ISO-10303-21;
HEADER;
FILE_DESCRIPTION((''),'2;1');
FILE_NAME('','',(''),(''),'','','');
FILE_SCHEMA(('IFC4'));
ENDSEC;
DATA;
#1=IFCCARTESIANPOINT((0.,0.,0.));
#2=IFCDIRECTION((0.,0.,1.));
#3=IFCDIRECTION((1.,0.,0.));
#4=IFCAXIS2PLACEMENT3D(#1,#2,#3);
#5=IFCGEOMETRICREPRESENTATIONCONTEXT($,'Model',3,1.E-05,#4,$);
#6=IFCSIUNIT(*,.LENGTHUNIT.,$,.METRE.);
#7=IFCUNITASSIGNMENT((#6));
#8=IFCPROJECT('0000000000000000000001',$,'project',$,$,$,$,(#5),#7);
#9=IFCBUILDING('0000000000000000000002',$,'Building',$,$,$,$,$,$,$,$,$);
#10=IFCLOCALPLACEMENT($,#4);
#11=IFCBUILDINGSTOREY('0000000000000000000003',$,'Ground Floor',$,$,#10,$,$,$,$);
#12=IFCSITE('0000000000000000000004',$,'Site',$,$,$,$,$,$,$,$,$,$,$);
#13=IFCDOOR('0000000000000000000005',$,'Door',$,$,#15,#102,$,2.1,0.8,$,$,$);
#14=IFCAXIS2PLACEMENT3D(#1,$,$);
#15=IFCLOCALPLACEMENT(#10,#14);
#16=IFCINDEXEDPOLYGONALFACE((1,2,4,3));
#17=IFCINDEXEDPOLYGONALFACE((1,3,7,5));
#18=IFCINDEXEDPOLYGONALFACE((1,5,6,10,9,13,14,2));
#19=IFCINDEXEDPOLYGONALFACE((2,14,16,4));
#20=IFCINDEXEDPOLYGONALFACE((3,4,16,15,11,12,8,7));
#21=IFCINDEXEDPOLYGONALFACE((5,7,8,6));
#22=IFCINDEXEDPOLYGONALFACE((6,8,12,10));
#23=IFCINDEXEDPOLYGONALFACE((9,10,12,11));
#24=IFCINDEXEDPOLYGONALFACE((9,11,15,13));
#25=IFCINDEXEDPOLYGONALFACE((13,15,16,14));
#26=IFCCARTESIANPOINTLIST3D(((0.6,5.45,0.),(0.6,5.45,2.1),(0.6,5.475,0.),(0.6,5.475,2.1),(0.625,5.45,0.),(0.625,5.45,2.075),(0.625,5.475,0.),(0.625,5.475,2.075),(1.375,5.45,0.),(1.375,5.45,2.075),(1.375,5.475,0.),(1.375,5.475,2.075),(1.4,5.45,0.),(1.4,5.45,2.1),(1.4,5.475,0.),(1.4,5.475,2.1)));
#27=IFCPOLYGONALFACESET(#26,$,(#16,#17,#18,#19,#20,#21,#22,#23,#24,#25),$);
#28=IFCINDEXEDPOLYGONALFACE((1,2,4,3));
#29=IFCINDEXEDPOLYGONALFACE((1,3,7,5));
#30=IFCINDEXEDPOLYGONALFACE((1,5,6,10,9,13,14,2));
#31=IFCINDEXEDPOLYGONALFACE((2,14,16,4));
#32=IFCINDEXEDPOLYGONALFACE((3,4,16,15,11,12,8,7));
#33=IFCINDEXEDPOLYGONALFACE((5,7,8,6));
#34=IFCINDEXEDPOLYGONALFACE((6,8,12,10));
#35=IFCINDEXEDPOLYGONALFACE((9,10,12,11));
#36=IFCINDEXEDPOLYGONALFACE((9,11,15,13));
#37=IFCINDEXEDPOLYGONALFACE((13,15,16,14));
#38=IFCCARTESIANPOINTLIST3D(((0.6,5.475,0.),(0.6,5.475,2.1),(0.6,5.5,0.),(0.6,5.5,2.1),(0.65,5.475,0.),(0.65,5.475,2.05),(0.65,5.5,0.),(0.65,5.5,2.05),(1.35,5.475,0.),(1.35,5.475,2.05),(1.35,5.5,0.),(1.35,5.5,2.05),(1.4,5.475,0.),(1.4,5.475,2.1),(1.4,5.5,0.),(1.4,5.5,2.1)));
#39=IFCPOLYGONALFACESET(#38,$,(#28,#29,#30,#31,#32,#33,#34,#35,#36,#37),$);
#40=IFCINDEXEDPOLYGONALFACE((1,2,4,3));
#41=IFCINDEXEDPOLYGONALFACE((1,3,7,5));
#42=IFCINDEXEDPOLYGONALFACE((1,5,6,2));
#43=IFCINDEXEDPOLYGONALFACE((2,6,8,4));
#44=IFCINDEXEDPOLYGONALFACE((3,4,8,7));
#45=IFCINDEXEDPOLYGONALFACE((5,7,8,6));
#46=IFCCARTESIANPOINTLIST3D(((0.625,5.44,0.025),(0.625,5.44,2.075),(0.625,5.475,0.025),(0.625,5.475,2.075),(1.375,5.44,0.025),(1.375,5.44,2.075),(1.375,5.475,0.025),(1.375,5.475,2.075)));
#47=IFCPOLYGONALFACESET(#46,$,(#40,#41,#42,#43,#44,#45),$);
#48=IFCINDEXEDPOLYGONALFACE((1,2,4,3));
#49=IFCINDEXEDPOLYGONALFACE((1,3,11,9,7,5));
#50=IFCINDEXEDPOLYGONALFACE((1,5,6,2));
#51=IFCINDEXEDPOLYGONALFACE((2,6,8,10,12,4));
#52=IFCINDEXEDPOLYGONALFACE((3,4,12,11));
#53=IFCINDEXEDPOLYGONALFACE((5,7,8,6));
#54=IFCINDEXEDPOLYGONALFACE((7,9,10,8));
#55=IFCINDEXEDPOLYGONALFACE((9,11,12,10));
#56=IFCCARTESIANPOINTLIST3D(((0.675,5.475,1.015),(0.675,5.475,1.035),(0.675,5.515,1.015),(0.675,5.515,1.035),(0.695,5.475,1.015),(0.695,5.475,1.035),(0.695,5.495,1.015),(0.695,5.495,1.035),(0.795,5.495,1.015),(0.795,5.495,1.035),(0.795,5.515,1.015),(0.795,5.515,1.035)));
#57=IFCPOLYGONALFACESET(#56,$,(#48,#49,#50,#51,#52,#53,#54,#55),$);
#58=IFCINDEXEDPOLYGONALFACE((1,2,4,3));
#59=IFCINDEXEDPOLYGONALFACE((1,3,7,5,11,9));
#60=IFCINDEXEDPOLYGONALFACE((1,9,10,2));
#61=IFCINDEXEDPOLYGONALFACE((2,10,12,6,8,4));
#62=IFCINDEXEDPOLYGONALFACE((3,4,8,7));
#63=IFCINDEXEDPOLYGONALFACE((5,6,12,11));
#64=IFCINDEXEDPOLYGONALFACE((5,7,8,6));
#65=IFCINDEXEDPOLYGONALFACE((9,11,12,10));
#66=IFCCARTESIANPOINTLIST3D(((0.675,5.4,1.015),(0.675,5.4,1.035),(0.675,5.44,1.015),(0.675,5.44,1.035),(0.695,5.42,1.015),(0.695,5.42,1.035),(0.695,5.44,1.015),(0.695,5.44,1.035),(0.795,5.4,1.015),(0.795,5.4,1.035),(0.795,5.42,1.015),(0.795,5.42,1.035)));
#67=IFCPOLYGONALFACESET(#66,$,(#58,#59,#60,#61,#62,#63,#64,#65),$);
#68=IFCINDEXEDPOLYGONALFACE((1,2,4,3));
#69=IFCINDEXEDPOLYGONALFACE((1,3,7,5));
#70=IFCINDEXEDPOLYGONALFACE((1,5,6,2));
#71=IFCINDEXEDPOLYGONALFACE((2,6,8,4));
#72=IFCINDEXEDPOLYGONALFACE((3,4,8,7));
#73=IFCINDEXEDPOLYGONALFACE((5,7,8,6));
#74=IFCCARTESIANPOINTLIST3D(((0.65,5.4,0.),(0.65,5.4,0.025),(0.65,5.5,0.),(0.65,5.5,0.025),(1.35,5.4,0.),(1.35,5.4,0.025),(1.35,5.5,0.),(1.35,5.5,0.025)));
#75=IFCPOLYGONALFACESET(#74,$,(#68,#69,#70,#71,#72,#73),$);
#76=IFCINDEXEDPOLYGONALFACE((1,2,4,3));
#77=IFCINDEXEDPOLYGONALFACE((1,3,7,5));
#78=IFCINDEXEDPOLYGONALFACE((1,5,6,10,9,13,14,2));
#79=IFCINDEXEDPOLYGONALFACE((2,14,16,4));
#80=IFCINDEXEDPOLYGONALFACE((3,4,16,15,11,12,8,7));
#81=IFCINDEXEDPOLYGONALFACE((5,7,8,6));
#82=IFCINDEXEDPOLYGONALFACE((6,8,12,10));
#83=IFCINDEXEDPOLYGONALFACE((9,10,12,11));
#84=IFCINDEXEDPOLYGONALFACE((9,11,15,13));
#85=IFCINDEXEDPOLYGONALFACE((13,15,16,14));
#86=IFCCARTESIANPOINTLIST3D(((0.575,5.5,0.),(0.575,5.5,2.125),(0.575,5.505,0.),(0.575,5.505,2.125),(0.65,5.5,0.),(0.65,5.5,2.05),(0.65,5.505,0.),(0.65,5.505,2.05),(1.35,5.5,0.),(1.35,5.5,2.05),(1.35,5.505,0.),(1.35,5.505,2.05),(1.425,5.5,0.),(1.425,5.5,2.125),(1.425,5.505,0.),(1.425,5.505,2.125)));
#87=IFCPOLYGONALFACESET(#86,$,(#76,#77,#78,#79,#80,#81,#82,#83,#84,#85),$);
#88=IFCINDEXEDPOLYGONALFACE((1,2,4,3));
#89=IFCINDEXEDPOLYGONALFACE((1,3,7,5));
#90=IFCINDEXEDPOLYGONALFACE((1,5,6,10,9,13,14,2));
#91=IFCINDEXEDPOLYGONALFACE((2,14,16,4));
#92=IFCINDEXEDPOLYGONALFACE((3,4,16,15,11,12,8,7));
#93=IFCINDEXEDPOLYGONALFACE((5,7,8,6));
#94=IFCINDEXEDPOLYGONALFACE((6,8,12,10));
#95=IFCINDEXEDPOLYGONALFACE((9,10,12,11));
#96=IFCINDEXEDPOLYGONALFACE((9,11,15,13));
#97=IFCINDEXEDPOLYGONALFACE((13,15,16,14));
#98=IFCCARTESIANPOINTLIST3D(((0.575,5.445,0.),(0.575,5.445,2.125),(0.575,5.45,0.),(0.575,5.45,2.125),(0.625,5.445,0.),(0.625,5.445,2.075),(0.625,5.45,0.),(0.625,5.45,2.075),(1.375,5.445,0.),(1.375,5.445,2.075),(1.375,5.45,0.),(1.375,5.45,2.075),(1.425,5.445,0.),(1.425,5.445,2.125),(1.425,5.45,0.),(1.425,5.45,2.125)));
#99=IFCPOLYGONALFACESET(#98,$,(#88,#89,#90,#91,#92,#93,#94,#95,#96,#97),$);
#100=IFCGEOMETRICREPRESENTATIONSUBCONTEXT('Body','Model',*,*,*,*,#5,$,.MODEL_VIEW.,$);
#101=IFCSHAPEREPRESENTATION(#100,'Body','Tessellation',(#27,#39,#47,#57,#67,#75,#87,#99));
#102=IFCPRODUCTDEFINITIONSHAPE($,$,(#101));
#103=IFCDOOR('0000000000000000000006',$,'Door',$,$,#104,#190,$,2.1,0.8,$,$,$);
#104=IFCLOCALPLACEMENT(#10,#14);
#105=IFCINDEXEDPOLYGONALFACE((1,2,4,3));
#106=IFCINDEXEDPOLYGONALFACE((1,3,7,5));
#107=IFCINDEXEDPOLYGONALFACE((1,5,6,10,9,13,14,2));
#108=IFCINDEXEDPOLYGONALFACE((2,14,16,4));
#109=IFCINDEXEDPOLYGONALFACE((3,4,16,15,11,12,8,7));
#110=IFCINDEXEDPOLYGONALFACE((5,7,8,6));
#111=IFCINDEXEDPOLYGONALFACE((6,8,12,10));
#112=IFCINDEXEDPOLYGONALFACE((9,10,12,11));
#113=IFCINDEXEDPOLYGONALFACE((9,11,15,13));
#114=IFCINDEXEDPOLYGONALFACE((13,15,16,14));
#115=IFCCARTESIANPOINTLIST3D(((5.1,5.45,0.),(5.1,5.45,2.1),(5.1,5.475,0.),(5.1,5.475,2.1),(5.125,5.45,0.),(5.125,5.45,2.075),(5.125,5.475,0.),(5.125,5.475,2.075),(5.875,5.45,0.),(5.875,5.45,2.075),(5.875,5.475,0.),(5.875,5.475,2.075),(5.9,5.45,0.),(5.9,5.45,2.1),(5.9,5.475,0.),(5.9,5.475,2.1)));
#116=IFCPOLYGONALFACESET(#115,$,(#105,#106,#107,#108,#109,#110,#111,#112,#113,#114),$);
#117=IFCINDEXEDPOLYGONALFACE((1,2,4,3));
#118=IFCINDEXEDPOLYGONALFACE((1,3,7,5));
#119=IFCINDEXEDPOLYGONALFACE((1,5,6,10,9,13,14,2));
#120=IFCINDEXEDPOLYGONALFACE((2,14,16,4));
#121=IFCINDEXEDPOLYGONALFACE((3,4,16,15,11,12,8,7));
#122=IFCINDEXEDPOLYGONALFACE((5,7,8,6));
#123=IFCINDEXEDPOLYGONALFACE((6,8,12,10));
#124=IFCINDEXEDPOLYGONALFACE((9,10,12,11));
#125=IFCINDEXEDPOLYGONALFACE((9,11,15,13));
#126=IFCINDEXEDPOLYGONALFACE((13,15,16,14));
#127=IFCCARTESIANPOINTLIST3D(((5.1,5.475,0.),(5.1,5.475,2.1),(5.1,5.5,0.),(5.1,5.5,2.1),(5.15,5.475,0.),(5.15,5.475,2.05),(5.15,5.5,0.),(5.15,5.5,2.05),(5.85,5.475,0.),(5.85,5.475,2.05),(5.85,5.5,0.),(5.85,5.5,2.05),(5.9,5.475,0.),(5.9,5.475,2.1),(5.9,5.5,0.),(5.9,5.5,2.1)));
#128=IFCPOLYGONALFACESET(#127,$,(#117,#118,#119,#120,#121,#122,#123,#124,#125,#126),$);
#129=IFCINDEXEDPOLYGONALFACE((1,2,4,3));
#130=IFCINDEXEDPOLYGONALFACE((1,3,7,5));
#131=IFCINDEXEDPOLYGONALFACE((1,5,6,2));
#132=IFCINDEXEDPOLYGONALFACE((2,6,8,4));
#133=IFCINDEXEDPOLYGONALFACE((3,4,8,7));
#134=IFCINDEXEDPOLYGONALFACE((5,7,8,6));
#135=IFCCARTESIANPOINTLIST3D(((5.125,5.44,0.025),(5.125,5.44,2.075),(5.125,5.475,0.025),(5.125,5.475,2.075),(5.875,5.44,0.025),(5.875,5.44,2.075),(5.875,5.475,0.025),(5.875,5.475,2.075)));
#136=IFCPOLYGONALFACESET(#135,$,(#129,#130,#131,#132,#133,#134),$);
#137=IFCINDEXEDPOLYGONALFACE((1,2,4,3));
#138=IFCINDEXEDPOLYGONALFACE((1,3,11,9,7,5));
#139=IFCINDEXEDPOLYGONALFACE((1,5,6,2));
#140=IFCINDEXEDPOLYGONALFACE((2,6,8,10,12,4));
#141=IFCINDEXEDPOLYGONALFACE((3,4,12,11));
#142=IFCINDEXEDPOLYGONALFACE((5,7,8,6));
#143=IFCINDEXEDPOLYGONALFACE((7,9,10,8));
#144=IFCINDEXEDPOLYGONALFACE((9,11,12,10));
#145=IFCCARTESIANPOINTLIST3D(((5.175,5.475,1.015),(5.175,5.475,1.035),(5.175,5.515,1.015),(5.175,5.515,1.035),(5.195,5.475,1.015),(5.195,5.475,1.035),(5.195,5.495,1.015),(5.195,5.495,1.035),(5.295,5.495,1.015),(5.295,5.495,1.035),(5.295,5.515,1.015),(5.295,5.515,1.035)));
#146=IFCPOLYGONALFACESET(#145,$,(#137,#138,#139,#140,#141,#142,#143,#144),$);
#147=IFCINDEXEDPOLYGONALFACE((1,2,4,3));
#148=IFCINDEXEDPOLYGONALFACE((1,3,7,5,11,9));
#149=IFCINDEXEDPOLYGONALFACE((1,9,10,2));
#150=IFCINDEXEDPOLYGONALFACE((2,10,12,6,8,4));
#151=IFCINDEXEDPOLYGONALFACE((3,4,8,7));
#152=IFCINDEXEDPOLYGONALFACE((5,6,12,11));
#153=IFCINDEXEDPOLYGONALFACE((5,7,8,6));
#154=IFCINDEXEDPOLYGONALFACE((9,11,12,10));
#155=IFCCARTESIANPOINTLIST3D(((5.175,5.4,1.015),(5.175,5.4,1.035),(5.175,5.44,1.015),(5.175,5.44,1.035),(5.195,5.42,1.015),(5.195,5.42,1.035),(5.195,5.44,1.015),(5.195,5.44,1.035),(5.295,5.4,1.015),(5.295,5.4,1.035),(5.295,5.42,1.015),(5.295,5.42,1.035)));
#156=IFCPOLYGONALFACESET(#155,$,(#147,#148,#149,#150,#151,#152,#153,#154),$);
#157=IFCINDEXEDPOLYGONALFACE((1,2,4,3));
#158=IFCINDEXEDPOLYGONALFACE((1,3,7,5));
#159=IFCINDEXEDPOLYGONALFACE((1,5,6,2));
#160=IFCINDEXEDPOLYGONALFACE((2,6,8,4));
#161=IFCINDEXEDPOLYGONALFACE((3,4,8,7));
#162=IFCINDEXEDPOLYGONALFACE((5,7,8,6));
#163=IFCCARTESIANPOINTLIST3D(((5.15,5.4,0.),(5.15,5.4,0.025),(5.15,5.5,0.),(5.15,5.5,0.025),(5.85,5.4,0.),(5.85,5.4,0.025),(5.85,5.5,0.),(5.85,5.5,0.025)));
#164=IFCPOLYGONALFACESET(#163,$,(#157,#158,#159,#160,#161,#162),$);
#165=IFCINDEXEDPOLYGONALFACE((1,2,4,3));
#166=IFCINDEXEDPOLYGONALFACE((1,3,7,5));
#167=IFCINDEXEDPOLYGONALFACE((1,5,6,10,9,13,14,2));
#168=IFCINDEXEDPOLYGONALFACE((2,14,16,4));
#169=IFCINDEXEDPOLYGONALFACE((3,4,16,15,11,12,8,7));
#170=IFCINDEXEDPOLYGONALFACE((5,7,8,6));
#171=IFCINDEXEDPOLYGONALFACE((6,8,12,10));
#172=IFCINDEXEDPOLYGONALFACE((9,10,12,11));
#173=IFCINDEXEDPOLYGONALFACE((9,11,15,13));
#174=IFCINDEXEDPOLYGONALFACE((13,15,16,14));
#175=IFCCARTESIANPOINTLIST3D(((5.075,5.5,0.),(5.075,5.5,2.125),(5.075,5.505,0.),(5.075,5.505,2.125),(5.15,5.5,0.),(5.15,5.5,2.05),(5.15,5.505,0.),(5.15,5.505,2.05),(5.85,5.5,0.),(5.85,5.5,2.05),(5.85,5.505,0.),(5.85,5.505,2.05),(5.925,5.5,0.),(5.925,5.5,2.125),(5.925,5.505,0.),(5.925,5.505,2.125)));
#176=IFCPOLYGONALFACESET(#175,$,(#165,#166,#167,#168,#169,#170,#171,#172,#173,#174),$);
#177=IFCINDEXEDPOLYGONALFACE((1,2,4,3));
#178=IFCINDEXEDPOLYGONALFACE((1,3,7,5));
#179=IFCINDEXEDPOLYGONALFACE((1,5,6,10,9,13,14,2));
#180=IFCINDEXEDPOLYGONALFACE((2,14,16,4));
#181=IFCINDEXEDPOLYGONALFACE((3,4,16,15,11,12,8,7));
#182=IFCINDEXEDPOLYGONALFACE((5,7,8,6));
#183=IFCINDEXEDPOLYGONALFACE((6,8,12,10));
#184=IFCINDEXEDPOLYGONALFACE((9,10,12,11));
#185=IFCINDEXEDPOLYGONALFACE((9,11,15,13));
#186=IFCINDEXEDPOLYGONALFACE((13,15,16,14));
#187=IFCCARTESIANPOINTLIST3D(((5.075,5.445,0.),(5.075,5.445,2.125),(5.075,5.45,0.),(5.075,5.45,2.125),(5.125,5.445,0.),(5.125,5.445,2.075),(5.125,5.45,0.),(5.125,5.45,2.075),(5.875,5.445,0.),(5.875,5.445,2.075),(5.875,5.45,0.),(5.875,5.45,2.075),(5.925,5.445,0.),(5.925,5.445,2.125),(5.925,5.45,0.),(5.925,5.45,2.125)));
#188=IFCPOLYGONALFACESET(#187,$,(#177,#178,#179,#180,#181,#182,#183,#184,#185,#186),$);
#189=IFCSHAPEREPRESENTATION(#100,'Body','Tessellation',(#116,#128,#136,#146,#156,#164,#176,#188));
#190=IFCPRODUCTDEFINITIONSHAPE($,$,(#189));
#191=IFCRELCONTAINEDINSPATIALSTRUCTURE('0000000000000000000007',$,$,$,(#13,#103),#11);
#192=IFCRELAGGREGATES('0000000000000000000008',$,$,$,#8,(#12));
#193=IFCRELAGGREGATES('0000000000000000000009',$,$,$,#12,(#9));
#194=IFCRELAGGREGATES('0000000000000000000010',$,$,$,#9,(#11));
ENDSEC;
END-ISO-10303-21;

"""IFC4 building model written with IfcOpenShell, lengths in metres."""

from ifc_helpers import new_model, si_unit, frame, origin_with_axes, place, context, subcontext, project, spatial, line, indexed_curve, outline, extrude, element, save


model = new_model("IFC4")

# Units and contexts
model_context = context("Model", 3, precision=1e-05, world=origin_with_axes())
body_context = subcontext(model_context, "Body", "Model", "MODEL_VIEW")
ifc_project = project(units=[si_unit("LENGTHUNIT", "METRE")], contexts=[model_context])

# Site, building, storey
site = spatial("IfcSite", under=ifc_project, Name="Site")
building = spatial("IfcBuilding", under=site, Name="Building")
storey_placement = place(None, origin_with_axes())
storey = spatial("IfcBuildingStorey", under=building, at=storey_placement, Name="Ground Floor")

# Doors
door_1_placement = place(storey_placement, frame((1.4, 5.5, 0.0), z_axis=(0.0, 0.0, 1.0), x_axis=(-1.0, 0.0, 0.0)))
element("IfcDoor", 1, at=door_1_placement, inside=storey, Name="Door", OverallHeight=2.1, OverallWidth=0.8, context=body_context, shape_type="SweptSolid", body=[
    extrude(outline(indexed_curve([(0.0, 0.0), (0.0, 2.1), (0.8, 2.1), (0.8, 0.0), (0.775, 0.0), (0.775, 2.075), (0.025, 2.075), (0.025, 0.0)], segments=[line(1, 2, 3, 4, 5, 6, 7, 8, 1)])), frame((0.0, 0.025, 0.0), z_axis=(0.0, -1.0, 0.0), x_axis=(1.0, 0.0, 0.0)), (0.0, 0.0, -1.0), 0.025),
    extrude(outline(indexed_curve([(0.0, 0.0), (0.0, 2.1), (0.8, 2.1), (0.8, 0.0), (0.75, 0.0), (0.75, 2.05), (0.05, 2.05), (0.05, 0.0)], segments=[line(1, 2, 3, 4, 5, 6, 7, 8, 1)])), frame((0.0, 0.0, 0.0), z_axis=(0.0, -1.0, 0.0), x_axis=(1.0, 0.0, 0.0)), (0.0, 0.0, -1.0), 0.025),
    extrude(outline(indexed_curve([(0.0, 0.0), (0.75, 0.0), (0.75, 0.035), (0.0, 0.035)], segments=[line(1, 2, 3, 4, 1)])), frame((0.025, 0.025, 0.025), z_axis=(0.0, 0.0, 1.0), x_axis=(1.0, 0.0, 0.0)), (0.0, 0.0, 1.0), 2.05),
    extrude(outline(indexed_curve([(0.0, 0.0), (0.0, -0.04), (-0.12, -0.04), (-0.12, -0.02), (-0.02, -0.02), (-0.02, 0.0)], segments=[line(1, 2, 3, 4, 5, 6, 1)])), frame((0.725, 0.025, 1.015), z_axis=(0.0, 0.0, 1.0), x_axis=(1.0, 0.0, 0.0)), (0.0, 0.0, 1.0), 0.02),
    extrude(outline(indexed_curve([(0.0, 0.0), (0.0, 0.04), (-0.12, 0.04), (-0.12, 0.02), (-0.02, 0.02), (-0.02, 0.0)], segments=[line(1, 2, 3, 4, 5, 6, 1)])), frame((0.725, 0.06, 1.015), z_axis=(0.0, 0.0, 1.0), x_axis=(1.0, 0.0, 0.0)), (0.0, 0.0, 1.0), 0.02),
    extrude(outline(indexed_curve([(0.0, 0.0), (0.7, 0.0), (0.7, 0.1), (0.0, 0.1)], segments=[line(1, 2, 3, 4, 1)])), frame((0.05, 0.0, 0.0), z_axis=(0.0, 0.0, 1.0), x_axis=(1.0, 0.0, 0.0)), (0.0, 0.0, 1.0), 0.025),
    extrude(outline(indexed_curve([(0.0, 0.0), (0.0, 2.125), (0.85, 2.125), (0.85, 0.0), (0.775, 0.0), (0.775, 2.05), (0.075, 2.05), (0.075, 0.0)], segments=[line(1, 2, 3, 4, 5, 6, 7, 8, 1)])), frame((-0.025, -0.005, 0.0), z_axis=(0.0, -1.0, 0.0), x_axis=(1.0, 0.0, 0.0)), (0.0, 0.0, -1.0), 0.005),
    extrude(outline(indexed_curve([(0.0, 0.0), (0.0, 2.125), (0.85, 2.125), (0.85, 0.0), (0.8, 0.0), (0.8, 2.075), (0.05, 2.075), (0.05, 0.0)], segments=[line(1, 2, 3, 4, 5, 6, 7, 8, 1)])), frame((-0.025, 0.05, 0.0), z_axis=(0.0, -1.0, 0.0), x_axis=(1.0, 0.0, 0.0)), (0.0, 0.0, -1.0), 0.005),
])
door_2_placement = place(storey_placement, frame((5.9, 5.5, 0.0), z_axis=(0.0, 0.0, 1.0), x_axis=(-1.0, 0.0, 0.0)))
element("IfcDoor", 2, at=door_2_placement, inside=storey, Name="Door", OverallHeight=2.1, OverallWidth=0.8, context=body_context, shape_type="SweptSolid", body=[
    extrude(outline(indexed_curve([(0.0, 0.0), (0.0, 2.1), (0.8, 2.1), (0.8, 0.0), (0.775, 0.0), (0.775, 2.075), (0.025, 2.075), (0.025, 0.0)], segments=[line(1, 2, 3, 4, 5, 6, 7, 8, 1)])), frame((0.0, 0.025, 0.0), z_axis=(0.0, -1.0, 0.0), x_axis=(1.0, 0.0, 0.0)), (0.0, 0.0, -1.0), 0.025),
    extrude(outline(indexed_curve([(0.0, 0.0), (0.0, 2.1), (0.8, 2.1), (0.8, 0.0), (0.75, 0.0), (0.75, 2.05), (0.05, 2.05), (0.05, 0.0)], segments=[line(1, 2, 3, 4, 5, 6, 7, 8, 1)])), frame((0.0, 0.0, 0.0), z_axis=(0.0, -1.0, 0.0), x_axis=(1.0, 0.0, 0.0)), (0.0, 0.0, -1.0), 0.025),
    extrude(outline(indexed_curve([(0.0, 0.0), (0.75, 0.0), (0.75, 0.035), (0.0, 0.035)], segments=[line(1, 2, 3, 4, 1)])), frame((0.025, 0.025, 0.025), z_axis=(0.0, 0.0, 1.0), x_axis=(1.0, 0.0, 0.0)), (0.0, 0.0, 1.0), 2.05),
    extrude(outline(indexed_curve([(0.0, 0.0), (0.0, -0.04), (-0.12, -0.04), (-0.12, -0.02), (-0.02, -0.02), (-0.02, 0.0)], segments=[line(1, 2, 3, 4, 5, 6, 1)])), frame((0.725, 0.025, 1.015), z_axis=(0.0, 0.0, 1.0), x_axis=(1.0, 0.0, 0.0)), (0.0, 0.0, 1.0), 0.02),
    extrude(outline(indexed_curve([(0.0, 0.0), (0.0, 0.04), (-0.12, 0.04), (-0.12, 0.02), (-0.02, 0.02), (-0.02, 0.0)], segments=[line(1, 2, 3, 4, 5, 6, 1)])), frame((0.725, 0.06, 1.015), z_axis=(0.0, 0.0, 1.0), x_axis=(1.0, 0.0, 0.0)), (0.0, 0.0, 1.0), 0.02),
    extrude(outline(indexed_curve([(0.0, 0.0), (0.7, 0.0), (0.7, 0.1), (0.0, 0.1)], segments=[line(1, 2, 3, 4, 1)])), frame((0.05, 0.0, 0.0), z_axis=(0.0, 0.0, 1.0), x_axis=(1.0, 0.0, 0.0)), (0.0, 0.0, 1.0), 0.025),
    extrude(outline(indexed_curve([(0.0, 0.0), (0.0, 2.125), (0.85, 2.125), (0.85, 0.0), (0.775, 0.0), (0.775, 2.05), (0.075, 2.05), (0.075, 0.0)], segments=[line(1, 2, 3, 4, 5, 6, 7, 8, 1)])), frame((-0.025, -0.005, 0.0), z_axis=(0.0, -1.0, 0.0), x_axis=(1.0, 0.0, 0.0)), (0.0, 0.0, -1.0), 0.005),
    extrude(outline(indexed_curve([(0.0, 0.0), (0.0, 2.125), (0.85, 2.125), (0.85, 0.0), (0.8, 0.0), (0.8, 2.075), (0.05, 2.075), (0.05, 0.0)], segments=[line(1, 2, 3, 4, 5, 6, 7, 8, 1)])), frame((-0.025, 0.05, 0.0), z_axis=(0.0, -1.0, 0.0), x_axis=(1.0, 0.0, 0.0)), (0.0, 0.0, -1.0), 0.005),
])

save(model, "model.ifc")
